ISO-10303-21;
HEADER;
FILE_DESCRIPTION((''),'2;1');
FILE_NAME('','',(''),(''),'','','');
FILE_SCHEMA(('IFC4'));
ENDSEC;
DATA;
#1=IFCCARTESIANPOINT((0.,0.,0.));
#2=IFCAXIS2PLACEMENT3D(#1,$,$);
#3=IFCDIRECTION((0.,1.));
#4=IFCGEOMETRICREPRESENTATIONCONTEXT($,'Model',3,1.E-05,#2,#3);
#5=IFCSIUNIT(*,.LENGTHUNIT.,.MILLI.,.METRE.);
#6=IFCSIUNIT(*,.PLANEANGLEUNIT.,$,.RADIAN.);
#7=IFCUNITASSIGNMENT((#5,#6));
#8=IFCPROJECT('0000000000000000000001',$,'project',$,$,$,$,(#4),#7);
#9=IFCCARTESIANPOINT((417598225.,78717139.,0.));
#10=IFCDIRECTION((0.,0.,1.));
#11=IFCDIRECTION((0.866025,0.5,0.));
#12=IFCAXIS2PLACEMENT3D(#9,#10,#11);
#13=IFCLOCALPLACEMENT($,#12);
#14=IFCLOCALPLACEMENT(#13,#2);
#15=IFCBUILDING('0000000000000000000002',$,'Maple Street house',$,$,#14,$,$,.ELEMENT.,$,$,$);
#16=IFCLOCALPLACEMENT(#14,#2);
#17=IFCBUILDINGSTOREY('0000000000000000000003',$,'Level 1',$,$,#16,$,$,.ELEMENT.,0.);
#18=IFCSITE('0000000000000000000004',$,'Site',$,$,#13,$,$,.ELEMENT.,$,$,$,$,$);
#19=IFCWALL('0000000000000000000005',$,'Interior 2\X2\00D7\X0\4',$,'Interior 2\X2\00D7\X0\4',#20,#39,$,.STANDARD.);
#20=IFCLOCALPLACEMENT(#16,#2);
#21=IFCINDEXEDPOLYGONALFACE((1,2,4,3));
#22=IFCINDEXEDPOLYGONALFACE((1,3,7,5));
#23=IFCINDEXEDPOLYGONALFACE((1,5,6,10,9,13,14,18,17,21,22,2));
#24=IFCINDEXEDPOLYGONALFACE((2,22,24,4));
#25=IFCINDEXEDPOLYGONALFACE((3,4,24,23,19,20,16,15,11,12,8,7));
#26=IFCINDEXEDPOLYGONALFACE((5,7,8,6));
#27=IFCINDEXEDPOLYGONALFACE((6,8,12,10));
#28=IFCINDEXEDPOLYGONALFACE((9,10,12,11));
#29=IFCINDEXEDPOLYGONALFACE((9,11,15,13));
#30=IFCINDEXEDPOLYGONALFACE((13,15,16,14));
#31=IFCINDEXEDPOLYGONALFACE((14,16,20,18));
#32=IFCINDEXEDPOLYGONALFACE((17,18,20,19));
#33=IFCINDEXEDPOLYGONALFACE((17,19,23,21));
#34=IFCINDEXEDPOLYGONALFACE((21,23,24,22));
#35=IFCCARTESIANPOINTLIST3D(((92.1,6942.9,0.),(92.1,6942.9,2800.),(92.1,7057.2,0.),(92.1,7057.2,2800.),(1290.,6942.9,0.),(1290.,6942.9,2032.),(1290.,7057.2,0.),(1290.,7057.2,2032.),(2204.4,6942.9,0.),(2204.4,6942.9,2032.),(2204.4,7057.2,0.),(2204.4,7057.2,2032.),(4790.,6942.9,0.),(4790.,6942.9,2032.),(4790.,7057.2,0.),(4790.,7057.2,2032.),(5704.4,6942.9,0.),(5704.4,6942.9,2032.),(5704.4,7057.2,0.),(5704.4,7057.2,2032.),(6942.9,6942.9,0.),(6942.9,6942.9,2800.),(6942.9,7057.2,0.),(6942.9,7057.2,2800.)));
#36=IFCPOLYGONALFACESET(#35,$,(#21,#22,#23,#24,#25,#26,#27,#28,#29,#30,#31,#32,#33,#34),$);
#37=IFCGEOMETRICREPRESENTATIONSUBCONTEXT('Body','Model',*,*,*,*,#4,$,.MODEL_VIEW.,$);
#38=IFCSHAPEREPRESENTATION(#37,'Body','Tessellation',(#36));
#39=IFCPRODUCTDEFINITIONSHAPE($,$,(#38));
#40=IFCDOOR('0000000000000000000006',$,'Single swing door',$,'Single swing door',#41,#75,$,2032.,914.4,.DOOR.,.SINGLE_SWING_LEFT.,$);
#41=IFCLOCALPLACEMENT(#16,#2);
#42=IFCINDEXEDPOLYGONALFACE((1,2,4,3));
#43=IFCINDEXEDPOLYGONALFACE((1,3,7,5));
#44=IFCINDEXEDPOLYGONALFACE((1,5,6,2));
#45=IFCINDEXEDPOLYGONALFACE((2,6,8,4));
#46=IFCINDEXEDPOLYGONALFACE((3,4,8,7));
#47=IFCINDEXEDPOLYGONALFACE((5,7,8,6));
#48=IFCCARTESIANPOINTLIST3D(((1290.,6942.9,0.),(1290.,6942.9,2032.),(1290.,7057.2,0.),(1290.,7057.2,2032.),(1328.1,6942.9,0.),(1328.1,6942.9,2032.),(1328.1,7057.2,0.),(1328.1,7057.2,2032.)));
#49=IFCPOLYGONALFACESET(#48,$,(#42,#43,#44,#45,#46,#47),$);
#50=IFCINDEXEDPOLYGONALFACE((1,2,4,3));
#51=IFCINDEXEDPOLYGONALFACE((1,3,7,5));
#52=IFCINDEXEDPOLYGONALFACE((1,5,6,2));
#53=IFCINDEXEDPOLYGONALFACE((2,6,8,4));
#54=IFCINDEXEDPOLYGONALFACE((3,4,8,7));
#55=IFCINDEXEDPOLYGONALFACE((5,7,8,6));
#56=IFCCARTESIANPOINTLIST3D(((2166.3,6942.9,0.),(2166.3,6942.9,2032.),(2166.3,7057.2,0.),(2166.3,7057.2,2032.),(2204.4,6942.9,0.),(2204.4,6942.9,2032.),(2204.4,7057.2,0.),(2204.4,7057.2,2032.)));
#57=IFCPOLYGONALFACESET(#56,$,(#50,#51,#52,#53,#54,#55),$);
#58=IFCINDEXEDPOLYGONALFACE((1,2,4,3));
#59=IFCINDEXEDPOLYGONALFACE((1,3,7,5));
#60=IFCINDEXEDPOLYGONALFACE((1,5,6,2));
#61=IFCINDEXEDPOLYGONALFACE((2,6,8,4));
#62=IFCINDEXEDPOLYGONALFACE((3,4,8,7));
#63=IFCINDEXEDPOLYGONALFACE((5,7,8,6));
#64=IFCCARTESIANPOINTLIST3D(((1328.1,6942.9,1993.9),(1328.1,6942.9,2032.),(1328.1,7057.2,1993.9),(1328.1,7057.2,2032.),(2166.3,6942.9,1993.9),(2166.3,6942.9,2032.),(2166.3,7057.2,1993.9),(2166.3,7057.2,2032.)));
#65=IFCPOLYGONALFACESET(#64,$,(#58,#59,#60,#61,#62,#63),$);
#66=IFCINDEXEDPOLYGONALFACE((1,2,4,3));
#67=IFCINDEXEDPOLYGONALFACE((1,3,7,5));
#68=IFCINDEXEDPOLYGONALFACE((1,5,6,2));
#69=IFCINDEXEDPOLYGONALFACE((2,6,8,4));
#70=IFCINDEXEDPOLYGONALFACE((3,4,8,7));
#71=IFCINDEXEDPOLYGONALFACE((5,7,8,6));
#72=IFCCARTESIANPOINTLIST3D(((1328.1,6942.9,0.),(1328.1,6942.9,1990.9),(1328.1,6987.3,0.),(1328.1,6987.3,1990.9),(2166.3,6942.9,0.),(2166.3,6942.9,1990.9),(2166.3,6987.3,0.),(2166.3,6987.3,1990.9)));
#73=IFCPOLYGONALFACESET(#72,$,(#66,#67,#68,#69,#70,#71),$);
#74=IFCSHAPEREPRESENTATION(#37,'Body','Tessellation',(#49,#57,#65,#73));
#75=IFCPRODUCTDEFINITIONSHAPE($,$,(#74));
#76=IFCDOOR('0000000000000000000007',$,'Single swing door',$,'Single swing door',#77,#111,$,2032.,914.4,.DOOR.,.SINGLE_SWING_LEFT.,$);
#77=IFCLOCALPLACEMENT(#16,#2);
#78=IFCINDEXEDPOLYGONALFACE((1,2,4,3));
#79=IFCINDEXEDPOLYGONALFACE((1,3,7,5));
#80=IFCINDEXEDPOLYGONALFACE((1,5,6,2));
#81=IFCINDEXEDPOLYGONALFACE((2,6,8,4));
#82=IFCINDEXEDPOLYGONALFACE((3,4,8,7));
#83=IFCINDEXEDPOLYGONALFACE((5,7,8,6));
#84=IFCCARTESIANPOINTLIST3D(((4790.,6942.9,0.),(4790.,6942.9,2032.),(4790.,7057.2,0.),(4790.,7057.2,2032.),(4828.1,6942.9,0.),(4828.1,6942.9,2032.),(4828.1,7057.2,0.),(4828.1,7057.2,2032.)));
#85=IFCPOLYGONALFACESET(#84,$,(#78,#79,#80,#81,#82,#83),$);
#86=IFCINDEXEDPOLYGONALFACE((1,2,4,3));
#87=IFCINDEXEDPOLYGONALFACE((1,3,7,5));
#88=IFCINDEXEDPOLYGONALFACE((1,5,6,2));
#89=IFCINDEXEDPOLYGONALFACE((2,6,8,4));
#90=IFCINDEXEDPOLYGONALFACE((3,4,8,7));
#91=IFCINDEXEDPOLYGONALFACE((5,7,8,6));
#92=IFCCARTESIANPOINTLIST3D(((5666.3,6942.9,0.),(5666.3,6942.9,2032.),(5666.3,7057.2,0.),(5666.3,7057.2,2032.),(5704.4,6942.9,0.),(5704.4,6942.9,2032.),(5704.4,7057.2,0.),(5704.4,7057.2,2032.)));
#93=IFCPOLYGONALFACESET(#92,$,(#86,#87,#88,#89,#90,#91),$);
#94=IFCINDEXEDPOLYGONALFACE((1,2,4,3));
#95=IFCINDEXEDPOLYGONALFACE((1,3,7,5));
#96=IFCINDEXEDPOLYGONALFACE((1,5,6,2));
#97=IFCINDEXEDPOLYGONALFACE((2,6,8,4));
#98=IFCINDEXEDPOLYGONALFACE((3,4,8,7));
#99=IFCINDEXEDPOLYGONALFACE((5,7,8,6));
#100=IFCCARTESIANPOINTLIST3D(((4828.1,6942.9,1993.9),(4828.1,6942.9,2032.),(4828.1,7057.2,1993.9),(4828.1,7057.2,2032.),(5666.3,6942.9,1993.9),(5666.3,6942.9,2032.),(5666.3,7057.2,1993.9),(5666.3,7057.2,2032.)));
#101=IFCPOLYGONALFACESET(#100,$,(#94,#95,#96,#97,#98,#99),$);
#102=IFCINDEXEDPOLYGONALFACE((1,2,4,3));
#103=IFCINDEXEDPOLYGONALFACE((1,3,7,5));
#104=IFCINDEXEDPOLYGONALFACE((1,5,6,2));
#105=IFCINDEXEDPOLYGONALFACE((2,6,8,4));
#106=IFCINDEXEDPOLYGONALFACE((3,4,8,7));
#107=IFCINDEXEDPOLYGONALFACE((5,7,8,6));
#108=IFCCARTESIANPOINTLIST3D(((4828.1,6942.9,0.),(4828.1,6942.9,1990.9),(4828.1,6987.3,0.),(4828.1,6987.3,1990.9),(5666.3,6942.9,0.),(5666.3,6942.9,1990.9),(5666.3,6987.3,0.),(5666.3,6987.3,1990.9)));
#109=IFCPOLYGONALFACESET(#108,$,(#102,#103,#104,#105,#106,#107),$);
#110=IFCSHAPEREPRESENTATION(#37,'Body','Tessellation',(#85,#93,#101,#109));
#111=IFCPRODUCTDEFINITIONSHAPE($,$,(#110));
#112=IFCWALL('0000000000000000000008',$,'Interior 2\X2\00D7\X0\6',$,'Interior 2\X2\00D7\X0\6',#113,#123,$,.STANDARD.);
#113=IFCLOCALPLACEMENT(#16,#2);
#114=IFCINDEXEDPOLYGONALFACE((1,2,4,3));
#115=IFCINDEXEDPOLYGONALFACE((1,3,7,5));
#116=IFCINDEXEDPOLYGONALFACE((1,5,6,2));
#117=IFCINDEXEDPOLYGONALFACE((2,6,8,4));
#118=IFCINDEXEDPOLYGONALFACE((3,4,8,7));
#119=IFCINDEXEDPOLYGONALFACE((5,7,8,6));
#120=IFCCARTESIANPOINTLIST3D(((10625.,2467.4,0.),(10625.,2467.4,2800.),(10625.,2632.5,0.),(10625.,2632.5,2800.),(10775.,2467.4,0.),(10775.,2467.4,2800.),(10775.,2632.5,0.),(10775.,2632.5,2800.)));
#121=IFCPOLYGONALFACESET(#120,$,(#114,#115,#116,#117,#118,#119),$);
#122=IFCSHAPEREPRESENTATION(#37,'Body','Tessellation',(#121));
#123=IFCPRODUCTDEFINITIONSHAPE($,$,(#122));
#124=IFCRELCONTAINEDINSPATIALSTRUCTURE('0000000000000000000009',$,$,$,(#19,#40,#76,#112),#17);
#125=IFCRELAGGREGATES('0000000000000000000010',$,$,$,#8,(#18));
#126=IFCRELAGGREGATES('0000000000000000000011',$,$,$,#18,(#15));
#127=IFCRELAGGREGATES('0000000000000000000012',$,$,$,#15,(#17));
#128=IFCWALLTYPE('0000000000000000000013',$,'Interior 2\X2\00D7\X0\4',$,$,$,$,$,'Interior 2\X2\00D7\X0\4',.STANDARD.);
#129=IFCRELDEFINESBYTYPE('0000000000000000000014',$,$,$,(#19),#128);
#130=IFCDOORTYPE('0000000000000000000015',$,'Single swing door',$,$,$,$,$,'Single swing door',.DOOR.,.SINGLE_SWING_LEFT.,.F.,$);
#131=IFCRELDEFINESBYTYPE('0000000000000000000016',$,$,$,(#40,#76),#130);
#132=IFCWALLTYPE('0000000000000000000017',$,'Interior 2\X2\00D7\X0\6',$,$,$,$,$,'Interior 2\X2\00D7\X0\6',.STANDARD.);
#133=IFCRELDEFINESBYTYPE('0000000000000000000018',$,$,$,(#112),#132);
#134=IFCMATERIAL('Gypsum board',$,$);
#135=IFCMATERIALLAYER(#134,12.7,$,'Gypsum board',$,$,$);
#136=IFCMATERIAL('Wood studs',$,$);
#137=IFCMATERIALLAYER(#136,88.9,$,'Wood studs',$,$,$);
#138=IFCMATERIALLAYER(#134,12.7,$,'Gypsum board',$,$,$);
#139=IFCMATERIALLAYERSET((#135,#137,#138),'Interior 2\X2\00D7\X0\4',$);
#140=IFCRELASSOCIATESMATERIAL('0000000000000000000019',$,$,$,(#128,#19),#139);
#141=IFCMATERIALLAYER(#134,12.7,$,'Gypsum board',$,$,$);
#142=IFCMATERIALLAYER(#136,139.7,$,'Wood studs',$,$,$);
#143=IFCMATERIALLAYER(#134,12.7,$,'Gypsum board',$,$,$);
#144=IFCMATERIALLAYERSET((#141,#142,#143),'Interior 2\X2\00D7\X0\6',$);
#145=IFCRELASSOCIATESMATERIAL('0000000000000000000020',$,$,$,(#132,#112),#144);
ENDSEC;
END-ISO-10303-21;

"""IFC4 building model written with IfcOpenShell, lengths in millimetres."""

from ifc_helpers import new_model, si_unit, direction, frame, origin, origin_with_axes, place, context, subcontext, project, spatial, polyline, outline, extrude, material, layer, layer_set, layer_usage, type_object, element, fill, save


model = new_model("IFC4")

# Units and contexts
model_context = context("Model", 3, precision=1e-05, world=origin(), true_north=direction((0.0, 1.0)))
body_context = subcontext(model_context, "Body", "Model", "MODEL_VIEW")
ifc_project = project(units=[si_unit("LENGTHUNIT", "METRE", prefix="MILLI"), si_unit("PLANEANGLEUNIT", "RADIAN")], contexts=[model_context])

# Site, building, storey
site_placement = place(None, frame((417598225.0, 78717139.0, 0.0), z_axis=(0.0, 0.0, 1.0), x_axis=(0.866025, 0.5, 0.0)))
site = spatial("IfcSite", under=ifc_project, at=site_placement, Name="Site", CompositionType="ELEMENT")
building_placement = place(site_placement, origin())
building = spatial("IfcBuilding", under=site, at=building_placement, Name="Maple Street house", CompositionType="ELEMENT")
storey_placement = place(building_placement, origin())
storey = spatial("IfcBuildingStorey", under=building, at=storey_placement, Name="Level 1", CompositionType="ELEMENT", Elevation=0.0)

# Shared definitions
ifc_material_1 = material(Name="Wood studs")
ifc_material_2 = material(Name="Gypsum board")

# Wall, openings, doors
ifc_layer_1 = layer(ifc_material_2, 12.7, Name="Gypsum board")
ifc_layer_2 = layer(ifc_material_1, 88.9, Name="Wood studs")
ifc_layer_3 = layer(ifc_material_2, 12.7, Name="Gypsum board")
ifc_layer_set_1 = layer_set([ifc_layer_1, ifc_layer_2, ifc_layer_3], Name="Interior 2×4")
ifc_layer_usage_1 = layer_usage(ifc_layer_set_1, "AXIS2", "NEGATIVE", 57.1)
wall_type_1 = type_object("IfcWallType", Name="Interior 2×4", ElementType="Interior 2×4", PredefinedType="STANDARD", material=ifc_layer_set_1)
wall_1_placement = place(storey_placement, frame((0.0, 7000.0, 0.0), z_axis=(0.0, 0.0, 1.0), x_axis=(1.0, 0.0, 0.0)))
wall_1 = element("IfcWall", 1, at=wall_1_placement, inside=storey, type_object=wall_type_1, material=ifc_layer_usage_1, Name="Interior 2×4", ObjectType="Interior 2×4", PredefinedType="STANDARD", context=body_context, shape_type="SweptSolid", body=[
    extrude(outline(polyline([(92.1, -57.1), (6942.9, -57.1), (6942.9, 57.1), (92.1, 57.1), (92.1, -57.1)])), origin(), (0.0, 0.0, 1.0), 2800.0),
])
opening_1_placement = place(wall_1_placement, frame((1290.0, 0.0, 0.0), z_axis=(0.0, 0.0, 1.0), x_axis=(1.0, 0.0, 0.0)))
opening_1 = element("IfcOpeningElement", 2, at=opening_1_placement, cuts=wall_1, PredefinedType="OPENING", context=body_context, shape_type="SweptSolid", body=[
    extrude(outline(polyline([(0.0, -67.2), (914.4, -67.2), (914.4, 67.2), (0.0, 67.2), (0.0, -67.2)])), origin(), (0.0, 0.0, 1.0), 2032.0),
])
opening_2_placement = place(wall_1_placement, frame((4790.0, 0.0, 0.0), z_axis=(0.0, 0.0, 1.0), x_axis=(1.0, 0.0, 0.0)))
opening_2 = element("IfcOpeningElement", 3, at=opening_2_placement, cuts=wall_1, PredefinedType="OPENING", context=body_context, shape_type="SweptSolid", body=[
    extrude(outline(polyline([(0.0, -67.2), (914.4, -67.2), (914.4, 67.2), (0.0, 67.2), (0.0, -67.2)])), origin(), (0.0, 0.0, 1.0), 2032.0),
])
door_type_1 = type_object("IfcDoorType", Name="Single swing door", ElementType="Single swing door", OperationType="SINGLE_SWING_LEFT", ParameterTakesPrecedence=False, PredefinedType="DOOR")
door_1_placement = place(opening_1_placement, origin_with_axes())
door_1 = element("IfcDoor", 4, at=door_1_placement, inside=storey, type_object=door_type_1, Name="Single swing door", ObjectType="Single swing door", OperationType="SINGLE_SWING_LEFT", OverallHeight=2032.0, OverallWidth=914.4, PredefinedType="DOOR", context=body_context, shape_type="SweptSolid", body=[
    extrude(outline(polyline([(0.0, -57.1), (38.1, -57.1), (38.1, 57.1), (0.0, 57.1), (0.0, -57.1)])), origin(), (0.0, 0.0, 1.0), 2032.0),
    extrude(outline(polyline([(876.3, -57.1), (914.4, -57.1), (914.4, 57.1), (876.3, 57.1), (876.3, -57.1)])), origin(), (0.0, 0.0, 1.0), 2032.0),
    extrude(outline(polyline([(38.1, -57.1), (876.3, -57.1), (876.3, 57.1), (38.1, 57.1), (38.1, -57.1)])), frame((0.0, 0.0, 1993.9)), (0.0, 0.0, 1.0), 38.1),
    extrude(outline(polyline([(38.1, -57.1), (876.3, -57.1), (876.3, -12.7), (38.1, -12.7), (38.1, -57.1)])), origin(), (0.0, 0.0, 1.0), 1990.9),
])
fill(opening_1, door_1)
door_2_placement = place(opening_2_placement, origin_with_axes())
door_2 = element("IfcDoor", 5, at=door_2_placement, inside=storey, type_object=door_type_1, Name="Single swing door", ObjectType="Single swing door", OperationType="SINGLE_SWING_LEFT", OverallHeight=2032.0, OverallWidth=914.4, PredefinedType="DOOR", context=body_context, shape_type="SweptSolid", body=[
    extrude(outline(polyline([(0.0, -57.1), (38.1, -57.1), (38.1, 57.1), (0.0, 57.1), (0.0, -57.1)])), origin(), (0.0, 0.0, 1.0), 2032.0),
    extrude(outline(polyline([(876.3, -57.1), (914.4, -57.1), (914.4, 57.1), (876.3, 57.1), (876.3, -57.1)])), origin(), (0.0, 0.0, 1.0), 2032.0),
    extrude(outline(polyline([(38.1, -57.1), (876.3, -57.1), (876.3, 57.1), (38.1, 57.1), (38.1, -57.1)])), frame((0.0, 0.0, 1993.9)), (0.0, 0.0, 1.0), 38.1),
    extrude(outline(polyline([(38.1, -57.1), (876.3, -57.1), (876.3, -12.7), (38.1, -12.7), (38.1, -57.1)])), origin(), (0.0, 0.0, 1.0), 1990.9),
])
fill(opening_2, door_2)

# Wall
ifc_layer_4 = layer(ifc_material_2, 12.7, Name="Gypsum board")
ifc_layer_5 = layer(ifc_material_1, 139.7, Name="Wood studs")
ifc_layer_6 = layer(ifc_material_2, 12.7, Name="Gypsum board")
ifc_layer_set_2 = layer_set([ifc_layer_4, ifc_layer_5, ifc_layer_6], Name="Interior 2×6")
wall_type_2 = type_object("IfcWallType", Name="Interior 2×6", ElementType="Interior 2×6", PredefinedType="STANDARD", material=ifc_layer_set_2)
ifc_layer_usage_2 = layer_usage(ifc_layer_set_2, "AXIS2", "NEGATIVE", 82.5)
wall_2_placement = place(storey_placement, frame((10625.0, 2550.0, 0.0), z_axis=(0.0, 0.0, 1.0), x_axis=(1.0, 0.0, 0.0)))
element("IfcWall", 6, at=wall_2_placement, inside=storey, type_object=wall_type_2, material=ifc_layer_usage_2, Name="Interior 2×6", ObjectType="Interior 2×6", PredefinedType="STANDARD", context=body_context, shape_type="SweptSolid", body=[
    extrude(outline(polyline([(0.0, -82.5), (150.0, -82.5), (150.0, 82.5), (0.0, 82.5), (0.0, -82.5)])), origin(), (0.0, 0.0, 1.0), 2800.0),
])

save(model, "model.ifc")
